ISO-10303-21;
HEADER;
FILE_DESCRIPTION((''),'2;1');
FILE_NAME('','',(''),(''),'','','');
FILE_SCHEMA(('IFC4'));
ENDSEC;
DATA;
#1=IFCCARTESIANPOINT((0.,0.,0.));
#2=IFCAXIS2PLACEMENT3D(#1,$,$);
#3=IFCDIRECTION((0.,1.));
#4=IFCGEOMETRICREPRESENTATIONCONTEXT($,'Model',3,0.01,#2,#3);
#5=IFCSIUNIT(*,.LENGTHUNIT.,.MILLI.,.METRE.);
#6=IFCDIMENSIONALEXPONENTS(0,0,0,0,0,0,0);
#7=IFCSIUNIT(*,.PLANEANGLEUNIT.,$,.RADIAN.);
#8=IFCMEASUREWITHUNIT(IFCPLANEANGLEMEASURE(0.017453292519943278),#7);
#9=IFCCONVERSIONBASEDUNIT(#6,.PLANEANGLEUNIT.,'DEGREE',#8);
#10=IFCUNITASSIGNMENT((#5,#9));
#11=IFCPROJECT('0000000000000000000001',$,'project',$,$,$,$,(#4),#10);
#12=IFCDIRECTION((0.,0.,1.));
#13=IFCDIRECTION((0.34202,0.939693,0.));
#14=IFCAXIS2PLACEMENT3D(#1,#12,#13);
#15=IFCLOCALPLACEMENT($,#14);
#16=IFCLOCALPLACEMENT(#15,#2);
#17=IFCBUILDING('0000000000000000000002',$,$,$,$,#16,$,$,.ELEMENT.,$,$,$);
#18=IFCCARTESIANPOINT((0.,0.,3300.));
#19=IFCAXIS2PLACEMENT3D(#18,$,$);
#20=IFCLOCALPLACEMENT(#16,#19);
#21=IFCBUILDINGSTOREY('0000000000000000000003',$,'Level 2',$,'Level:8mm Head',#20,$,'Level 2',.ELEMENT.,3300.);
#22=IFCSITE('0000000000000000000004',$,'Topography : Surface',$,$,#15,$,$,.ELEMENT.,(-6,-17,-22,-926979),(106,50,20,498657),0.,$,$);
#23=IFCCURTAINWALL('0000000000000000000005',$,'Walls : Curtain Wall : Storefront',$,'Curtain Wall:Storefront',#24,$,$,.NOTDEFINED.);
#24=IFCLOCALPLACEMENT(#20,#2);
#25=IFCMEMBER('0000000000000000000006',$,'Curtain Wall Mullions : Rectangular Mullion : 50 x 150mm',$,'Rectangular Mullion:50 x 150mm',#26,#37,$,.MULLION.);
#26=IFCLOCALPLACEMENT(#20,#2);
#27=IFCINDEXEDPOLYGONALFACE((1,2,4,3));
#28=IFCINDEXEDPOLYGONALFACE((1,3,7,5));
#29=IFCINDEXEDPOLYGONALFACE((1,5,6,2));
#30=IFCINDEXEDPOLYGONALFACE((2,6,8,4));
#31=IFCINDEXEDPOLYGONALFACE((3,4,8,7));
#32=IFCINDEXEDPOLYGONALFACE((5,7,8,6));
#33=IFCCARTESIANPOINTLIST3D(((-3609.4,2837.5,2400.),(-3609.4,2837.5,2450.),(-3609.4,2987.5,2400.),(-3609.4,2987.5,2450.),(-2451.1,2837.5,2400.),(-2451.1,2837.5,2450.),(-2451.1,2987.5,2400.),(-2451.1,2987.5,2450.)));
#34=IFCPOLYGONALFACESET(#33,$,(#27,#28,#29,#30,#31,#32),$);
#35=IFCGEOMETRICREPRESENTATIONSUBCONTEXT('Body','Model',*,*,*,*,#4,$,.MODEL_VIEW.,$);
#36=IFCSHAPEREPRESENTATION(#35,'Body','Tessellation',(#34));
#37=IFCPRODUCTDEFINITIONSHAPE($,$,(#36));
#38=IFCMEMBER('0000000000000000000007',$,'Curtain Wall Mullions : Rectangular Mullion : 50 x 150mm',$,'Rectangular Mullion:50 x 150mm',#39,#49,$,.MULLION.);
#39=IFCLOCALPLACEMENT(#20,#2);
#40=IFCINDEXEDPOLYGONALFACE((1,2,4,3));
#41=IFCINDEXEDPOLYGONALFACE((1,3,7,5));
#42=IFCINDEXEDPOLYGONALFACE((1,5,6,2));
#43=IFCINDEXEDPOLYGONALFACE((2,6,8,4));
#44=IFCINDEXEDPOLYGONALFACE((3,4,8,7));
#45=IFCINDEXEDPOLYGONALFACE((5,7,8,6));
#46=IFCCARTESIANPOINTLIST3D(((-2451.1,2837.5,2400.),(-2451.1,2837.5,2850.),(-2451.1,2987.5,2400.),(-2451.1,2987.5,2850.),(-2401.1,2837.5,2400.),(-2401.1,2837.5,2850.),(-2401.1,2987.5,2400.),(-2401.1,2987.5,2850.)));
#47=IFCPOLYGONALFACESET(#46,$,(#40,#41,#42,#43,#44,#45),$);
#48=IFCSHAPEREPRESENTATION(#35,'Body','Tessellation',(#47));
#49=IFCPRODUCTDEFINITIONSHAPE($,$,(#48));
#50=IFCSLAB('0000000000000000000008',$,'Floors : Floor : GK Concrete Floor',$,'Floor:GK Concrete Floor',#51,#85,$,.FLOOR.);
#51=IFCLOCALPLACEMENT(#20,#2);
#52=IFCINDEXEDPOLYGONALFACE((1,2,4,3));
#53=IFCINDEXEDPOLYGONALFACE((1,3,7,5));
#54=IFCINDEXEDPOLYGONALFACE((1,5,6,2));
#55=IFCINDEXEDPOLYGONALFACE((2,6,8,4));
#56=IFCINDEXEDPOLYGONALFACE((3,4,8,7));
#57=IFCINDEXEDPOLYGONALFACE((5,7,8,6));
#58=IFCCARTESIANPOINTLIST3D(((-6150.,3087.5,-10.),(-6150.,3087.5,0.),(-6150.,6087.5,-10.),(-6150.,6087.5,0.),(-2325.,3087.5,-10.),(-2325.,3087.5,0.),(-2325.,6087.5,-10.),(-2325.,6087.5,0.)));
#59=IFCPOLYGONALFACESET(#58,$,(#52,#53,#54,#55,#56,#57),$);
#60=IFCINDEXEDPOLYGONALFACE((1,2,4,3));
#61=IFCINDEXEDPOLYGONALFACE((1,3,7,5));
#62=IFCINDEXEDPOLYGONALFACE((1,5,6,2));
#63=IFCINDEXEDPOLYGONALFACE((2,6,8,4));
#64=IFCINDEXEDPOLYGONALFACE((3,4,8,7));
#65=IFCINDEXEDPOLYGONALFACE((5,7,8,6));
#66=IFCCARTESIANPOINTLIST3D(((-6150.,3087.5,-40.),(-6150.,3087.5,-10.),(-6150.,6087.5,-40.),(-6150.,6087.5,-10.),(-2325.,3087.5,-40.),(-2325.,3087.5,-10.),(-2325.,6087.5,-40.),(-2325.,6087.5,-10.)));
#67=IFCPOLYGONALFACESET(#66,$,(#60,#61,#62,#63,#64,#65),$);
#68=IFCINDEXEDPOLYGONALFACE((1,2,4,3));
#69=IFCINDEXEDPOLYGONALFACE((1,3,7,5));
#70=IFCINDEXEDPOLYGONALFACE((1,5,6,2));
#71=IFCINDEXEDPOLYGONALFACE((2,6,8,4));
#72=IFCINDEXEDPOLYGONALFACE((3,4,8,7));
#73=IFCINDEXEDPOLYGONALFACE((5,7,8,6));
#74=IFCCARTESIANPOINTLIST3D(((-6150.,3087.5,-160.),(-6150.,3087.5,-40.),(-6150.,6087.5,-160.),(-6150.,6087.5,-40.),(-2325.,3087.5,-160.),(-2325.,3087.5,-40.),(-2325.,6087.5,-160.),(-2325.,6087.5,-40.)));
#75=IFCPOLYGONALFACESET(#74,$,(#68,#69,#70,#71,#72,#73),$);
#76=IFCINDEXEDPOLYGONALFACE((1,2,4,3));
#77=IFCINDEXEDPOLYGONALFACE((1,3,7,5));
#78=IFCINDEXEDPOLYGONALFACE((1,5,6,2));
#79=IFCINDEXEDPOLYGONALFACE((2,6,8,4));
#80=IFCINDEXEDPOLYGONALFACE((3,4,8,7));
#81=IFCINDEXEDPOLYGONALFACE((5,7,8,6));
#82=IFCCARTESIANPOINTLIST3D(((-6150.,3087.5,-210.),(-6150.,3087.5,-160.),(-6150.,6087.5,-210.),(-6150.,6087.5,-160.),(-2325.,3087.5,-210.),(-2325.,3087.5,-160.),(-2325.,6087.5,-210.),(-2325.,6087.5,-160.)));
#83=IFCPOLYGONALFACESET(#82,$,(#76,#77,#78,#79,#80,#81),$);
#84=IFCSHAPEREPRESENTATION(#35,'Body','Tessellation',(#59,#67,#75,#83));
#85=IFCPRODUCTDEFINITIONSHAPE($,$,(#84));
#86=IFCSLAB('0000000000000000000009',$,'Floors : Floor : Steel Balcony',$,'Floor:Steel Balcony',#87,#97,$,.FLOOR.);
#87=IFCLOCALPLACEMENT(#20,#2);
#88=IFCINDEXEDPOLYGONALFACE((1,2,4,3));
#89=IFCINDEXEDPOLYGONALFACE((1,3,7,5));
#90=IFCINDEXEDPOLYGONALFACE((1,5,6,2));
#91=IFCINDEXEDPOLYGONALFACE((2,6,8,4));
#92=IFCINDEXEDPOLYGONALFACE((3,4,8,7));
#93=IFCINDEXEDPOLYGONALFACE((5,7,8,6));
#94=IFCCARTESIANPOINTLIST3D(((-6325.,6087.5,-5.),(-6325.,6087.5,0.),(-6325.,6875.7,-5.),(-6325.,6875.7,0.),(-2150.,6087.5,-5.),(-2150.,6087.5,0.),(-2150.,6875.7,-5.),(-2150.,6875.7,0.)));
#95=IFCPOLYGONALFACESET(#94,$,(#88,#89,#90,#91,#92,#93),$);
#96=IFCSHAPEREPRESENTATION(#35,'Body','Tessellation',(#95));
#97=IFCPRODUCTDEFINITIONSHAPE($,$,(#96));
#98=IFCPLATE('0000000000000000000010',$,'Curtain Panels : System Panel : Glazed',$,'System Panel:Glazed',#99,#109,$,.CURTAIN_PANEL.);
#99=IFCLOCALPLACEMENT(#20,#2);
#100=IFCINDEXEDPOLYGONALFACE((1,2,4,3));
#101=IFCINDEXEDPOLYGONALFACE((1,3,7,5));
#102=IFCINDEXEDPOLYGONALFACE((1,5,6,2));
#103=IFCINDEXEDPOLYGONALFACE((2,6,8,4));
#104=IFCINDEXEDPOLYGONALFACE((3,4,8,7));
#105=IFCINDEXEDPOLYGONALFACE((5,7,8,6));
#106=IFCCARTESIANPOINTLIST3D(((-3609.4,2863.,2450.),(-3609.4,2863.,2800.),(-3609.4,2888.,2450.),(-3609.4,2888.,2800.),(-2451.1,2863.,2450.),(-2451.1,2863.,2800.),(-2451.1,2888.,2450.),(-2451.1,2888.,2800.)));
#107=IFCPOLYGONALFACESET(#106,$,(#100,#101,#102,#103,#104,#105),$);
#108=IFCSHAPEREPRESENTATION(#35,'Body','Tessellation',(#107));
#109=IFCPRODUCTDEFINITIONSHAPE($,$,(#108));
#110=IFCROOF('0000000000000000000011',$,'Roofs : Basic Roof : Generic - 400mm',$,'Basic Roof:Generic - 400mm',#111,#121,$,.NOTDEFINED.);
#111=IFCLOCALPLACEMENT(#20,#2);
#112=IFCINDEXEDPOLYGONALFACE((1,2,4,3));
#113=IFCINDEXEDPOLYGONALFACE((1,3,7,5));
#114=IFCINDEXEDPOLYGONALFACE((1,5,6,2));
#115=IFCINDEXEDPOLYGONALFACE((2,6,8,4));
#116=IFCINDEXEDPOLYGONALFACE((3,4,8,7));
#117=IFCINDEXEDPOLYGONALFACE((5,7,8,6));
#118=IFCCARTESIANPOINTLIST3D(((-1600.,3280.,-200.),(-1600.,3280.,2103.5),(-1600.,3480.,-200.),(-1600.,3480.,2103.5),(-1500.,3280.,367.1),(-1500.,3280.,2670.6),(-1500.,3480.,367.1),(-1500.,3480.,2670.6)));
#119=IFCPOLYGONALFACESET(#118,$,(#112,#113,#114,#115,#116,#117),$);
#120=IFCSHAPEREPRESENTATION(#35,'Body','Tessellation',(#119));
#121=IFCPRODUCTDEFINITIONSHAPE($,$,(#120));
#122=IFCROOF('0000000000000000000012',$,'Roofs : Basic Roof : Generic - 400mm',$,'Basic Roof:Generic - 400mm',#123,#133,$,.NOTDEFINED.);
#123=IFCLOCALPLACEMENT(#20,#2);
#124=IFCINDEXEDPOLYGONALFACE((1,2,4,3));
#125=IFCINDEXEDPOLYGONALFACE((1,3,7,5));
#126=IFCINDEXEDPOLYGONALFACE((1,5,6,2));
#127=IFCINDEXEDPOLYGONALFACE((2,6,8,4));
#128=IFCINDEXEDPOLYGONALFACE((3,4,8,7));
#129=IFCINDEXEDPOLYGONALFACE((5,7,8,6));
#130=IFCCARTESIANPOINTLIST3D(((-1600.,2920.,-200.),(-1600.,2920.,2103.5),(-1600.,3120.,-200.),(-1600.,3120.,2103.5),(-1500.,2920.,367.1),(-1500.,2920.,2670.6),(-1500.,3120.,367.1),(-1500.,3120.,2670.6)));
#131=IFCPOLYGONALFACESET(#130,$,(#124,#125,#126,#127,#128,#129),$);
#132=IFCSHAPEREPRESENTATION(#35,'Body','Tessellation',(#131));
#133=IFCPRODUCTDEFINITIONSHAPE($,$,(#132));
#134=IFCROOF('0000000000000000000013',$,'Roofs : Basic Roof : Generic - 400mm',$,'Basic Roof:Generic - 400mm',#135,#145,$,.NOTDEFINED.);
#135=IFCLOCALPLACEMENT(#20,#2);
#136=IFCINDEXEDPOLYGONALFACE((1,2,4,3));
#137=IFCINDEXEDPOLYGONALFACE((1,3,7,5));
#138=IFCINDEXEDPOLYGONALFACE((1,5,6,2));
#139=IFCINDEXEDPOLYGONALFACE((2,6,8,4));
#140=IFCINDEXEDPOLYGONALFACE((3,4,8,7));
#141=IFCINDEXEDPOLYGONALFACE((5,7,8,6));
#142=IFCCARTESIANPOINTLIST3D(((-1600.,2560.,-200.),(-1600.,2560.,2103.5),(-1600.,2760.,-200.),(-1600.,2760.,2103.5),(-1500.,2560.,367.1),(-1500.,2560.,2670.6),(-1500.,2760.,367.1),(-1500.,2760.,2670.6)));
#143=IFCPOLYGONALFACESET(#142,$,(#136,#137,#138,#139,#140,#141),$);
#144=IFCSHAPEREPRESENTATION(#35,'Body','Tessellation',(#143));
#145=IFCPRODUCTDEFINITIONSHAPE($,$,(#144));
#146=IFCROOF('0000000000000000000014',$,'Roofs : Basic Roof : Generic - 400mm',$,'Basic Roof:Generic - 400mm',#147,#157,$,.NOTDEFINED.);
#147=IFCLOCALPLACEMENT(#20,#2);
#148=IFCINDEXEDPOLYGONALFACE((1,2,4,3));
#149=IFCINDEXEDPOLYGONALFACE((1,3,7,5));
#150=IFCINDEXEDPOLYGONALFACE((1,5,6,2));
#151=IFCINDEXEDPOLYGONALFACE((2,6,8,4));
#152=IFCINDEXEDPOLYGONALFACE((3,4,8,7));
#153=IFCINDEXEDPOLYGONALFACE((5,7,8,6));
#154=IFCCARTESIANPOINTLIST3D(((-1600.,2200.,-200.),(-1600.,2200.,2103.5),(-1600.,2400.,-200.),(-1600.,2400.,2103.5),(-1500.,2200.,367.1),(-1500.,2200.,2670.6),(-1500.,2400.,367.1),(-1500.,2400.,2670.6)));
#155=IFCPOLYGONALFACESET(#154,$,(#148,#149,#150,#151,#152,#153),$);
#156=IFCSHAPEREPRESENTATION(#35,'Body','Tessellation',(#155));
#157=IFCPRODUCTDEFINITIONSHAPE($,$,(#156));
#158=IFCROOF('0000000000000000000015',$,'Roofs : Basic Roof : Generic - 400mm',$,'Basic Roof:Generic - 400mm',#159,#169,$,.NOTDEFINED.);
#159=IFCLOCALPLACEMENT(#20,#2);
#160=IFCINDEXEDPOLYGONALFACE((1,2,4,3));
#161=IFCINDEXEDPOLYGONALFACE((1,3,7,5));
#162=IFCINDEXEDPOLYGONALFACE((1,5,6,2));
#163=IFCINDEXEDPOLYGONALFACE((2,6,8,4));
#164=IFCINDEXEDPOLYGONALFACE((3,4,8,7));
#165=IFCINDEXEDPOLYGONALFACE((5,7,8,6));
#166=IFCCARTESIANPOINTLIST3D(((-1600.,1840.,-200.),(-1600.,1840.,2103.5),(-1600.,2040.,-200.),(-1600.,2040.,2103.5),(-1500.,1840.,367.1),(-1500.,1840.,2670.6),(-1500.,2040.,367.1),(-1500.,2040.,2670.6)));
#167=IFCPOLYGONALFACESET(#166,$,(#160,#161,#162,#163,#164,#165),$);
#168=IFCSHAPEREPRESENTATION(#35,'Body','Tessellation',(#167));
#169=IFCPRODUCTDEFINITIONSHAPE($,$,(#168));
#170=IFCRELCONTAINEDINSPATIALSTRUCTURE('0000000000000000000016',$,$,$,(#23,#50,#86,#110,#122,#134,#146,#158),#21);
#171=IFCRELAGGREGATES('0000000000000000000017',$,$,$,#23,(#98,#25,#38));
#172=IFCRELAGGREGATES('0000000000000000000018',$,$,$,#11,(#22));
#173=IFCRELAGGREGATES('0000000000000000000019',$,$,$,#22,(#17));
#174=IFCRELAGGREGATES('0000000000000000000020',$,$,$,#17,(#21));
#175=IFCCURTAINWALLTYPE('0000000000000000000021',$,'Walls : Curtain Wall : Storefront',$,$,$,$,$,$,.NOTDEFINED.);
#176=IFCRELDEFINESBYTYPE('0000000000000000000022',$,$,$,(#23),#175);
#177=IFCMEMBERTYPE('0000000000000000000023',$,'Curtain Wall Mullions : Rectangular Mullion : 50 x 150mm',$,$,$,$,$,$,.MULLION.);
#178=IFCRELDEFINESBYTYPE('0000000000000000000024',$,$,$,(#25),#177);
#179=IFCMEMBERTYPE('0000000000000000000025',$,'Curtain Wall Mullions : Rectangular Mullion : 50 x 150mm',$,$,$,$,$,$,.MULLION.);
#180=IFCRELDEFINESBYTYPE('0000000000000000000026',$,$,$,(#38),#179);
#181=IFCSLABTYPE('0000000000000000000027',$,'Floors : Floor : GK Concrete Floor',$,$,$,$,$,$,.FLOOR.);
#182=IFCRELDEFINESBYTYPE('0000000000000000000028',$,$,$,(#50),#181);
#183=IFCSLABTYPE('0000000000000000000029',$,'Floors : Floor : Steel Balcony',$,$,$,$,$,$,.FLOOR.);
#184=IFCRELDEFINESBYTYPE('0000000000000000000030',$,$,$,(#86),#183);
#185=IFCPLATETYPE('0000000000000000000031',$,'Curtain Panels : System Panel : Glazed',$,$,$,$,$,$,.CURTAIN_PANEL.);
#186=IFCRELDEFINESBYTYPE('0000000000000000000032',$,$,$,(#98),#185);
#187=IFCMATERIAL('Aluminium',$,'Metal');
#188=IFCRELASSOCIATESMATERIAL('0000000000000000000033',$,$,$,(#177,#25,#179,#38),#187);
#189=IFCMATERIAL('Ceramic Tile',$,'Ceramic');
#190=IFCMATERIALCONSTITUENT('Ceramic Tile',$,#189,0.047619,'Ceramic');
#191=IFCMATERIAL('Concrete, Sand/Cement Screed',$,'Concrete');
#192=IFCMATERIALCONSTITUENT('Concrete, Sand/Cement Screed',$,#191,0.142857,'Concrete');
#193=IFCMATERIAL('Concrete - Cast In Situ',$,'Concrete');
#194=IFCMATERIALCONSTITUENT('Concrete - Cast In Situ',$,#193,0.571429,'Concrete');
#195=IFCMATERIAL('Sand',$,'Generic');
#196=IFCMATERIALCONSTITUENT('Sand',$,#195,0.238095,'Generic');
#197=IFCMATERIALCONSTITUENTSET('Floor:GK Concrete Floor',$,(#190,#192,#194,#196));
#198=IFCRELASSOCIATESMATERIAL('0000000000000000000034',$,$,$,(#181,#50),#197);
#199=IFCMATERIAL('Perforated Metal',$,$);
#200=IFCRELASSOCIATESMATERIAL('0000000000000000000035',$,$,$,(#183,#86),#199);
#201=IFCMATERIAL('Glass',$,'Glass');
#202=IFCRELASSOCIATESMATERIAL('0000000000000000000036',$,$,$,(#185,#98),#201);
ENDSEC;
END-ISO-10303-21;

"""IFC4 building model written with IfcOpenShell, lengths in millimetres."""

from ifc_helpers import new_model, entity, si_unit, converted_unit, direction, frame, origin, place, context, subcontext, project, spatial, indexed_curve, outline, extrude, source, transform, mapped, material, constituent, constituent_set, type_object, type_shapes, element, aggregate, save


model = new_model("IFC4")

# Units and contexts
model_context = context("Model", 3, precision=0.01, world=origin(), true_north=direction((0.0, 1.0)))
body_context = subcontext(model_context, "Body", "Model", "MODEL_VIEW")
ifc_project = project(units=[si_unit("LENGTHUNIT", "METRE", prefix="MILLI"), converted_unit("PLANEANGLEUNIT", "DEGREE", entity("IfcPlaneAngleMeasure", 0.017453292519943278), si_unit("PLANEANGLEUNIT", "RADIAN"), dimensions=[0, 0, 0, 0, 0, 0, 0])], contexts=[model_context])

# Site, building, storey
site_placement = place(None, frame((0.0, 0.0, 0.0), z_axis=(0.0, 0.0, 1.0), x_axis=(0.34202, 0.939693, 0.0)))
site = spatial("IfcSite", under=ifc_project, at=site_placement, Name="Topography : Surface", CompositionType="ELEMENT", RefLatitude=(-6, -17, -22, -926979), RefLongitude=(106, 50, 20, 498657), RefElevation=0.0)
building_placement = place(site_placement, origin())
building = spatial("IfcBuilding", under=site, at=building_placement, CompositionType="ELEMENT")
storey_placement = place(building_placement, frame((0.0, 0.0, 3300.0)))
storey = spatial("IfcBuildingStorey", under=building, at=storey_placement, Name="Level 2", ObjectType="Level:8mm Head", LongName="Level 2", CompositionType="ELEMENT", Elevation=3300.0)

# Curtain wall, members
curtain_wall_type = type_object("IfcCurtainWallType", Name="Walls : Curtain Wall : Storefront", PredefinedType="NOTDEFINED")
curtain_wall_placement = place(storey_placement, frame((0.0, 0.0, -3300.0)))
curtain_wall = element("IfcCurtainWall", 1, at=curtain_wall_placement, inside=storey, type_object=curtain_wall_type, Name="Walls : Curtain Wall : Storefront", ObjectType="Curtain Wall:Storefront", PredefinedType="NOTDEFINED")
ifc_material_1 = material(Name="Aluminium", Category="Metal")
member_type_1 = type_object("IfcMemberType", Name="Curtain Wall Mullions : Rectangular Mullion : 50 x 150mm", PredefinedType="MULLION", material=ifc_material_1)
shared_shape_1 = source(origin(), body_context, "Body", "SweptSolid", [
    extrude(outline(indexed_curve([(-25.0, -75.0), (25.0, -75.0), (25.0, 75.0), (-25.0, 75.0), (-25.0, -75.0)], self_intersect=False)), frame((-25.0, 0.0, -1158.3), z_axis=(0.0, 0.0, 1.0), x_axis=(-1.0, 0.0, 0.0)), (0.0, 0.0, 1.0), 1158.3),
])
type_shapes(member_type_1, [shared_shape_1])
member_1_placement = place(curtain_wall_placement, frame((-2451.1, 2912.5, 5700.0), z_axis=(1.0, 0.0, 0.0), x_axis=(0.0, 0.0, -1.0)))
member_1 = element("IfcMember", 2, at=member_1_placement, type_object=member_type_1, material=ifc_material_1, Name="Curtain Wall Mullions : Rectangular Mullion : 50 x 150mm", ObjectType="Rectangular Mullion:50 x 150mm", PredefinedType="MULLION", context=body_context, shape_type="MappedRepresentation", body=[
    mapped(shared_shape_1, transform((0.0, 0.0, 0.0), scale=1.0)),
])
member_type_2 = type_object("IfcMemberType", Name="Curtain Wall Mullions : Rectangular Mullion : 50 x 150mm", PredefinedType="MULLION", material=ifc_material_1)
shared_shape_2 = source(origin(), body_context, "Body", "SweptSolid", [
    extrude(outline(indexed_curve([(-25.0, -75.0), (25.0, -75.0), (25.0, 75.0), (-25.0, 75.0), (-25.0, -75.0)], self_intersect=False)), frame((-25.0, 0.0, -450.0), z_axis=(0.0, 0.0, 1.0), x_axis=(-1.0, 0.0, 0.0)), (0.0, 0.0, 1.0), 450.0),
])
type_shapes(member_type_2, [shared_shape_2])
member_2_placement = place(curtain_wall_placement, frame((-2401.1, 2912.5, 6150.0)))
member_2 = element("IfcMember", 3, at=member_2_placement, type_object=member_type_2, material=ifc_material_1, Name="Curtain Wall Mullions : Rectangular Mullion : 50 x 150mm", ObjectType="Rectangular Mullion:50 x 150mm", PredefinedType="MULLION", context=body_context, shape_type="MappedRepresentation", body=[
    mapped(shared_shape_2, transform((0.0, 0.0, 0.0), scale=1.0)),
])

# Slabs
ifc_material_2 = material(Name="Ceramic Tile", Category="Ceramic")
ifc_constituent_1 = constituent(ifc_material_2, Name="Ceramic Tile", Category="Ceramic", fraction=0.047619)
ifc_material_3 = material(Name="Concrete, Sand/Cement Screed", Category="Concrete")
ifc_constituent_2 = constituent(ifc_material_3, Name="Concrete, Sand/Cement Screed", Category="Concrete", fraction=0.142857)
ifc_material_4 = material(Name="Concrete - Cast In Situ", Category="Concrete")
ifc_constituent_3 = constituent(ifc_material_4, Name="Concrete - Cast In Situ", Category="Concrete", fraction=0.571429)
ifc_material_5 = material(Name="Sand", Category="Generic")
ifc_constituent_4 = constituent(ifc_material_5, Name="Sand", Category="Generic", fraction=0.238095)
ifc_constituent_set_1 = constituent_set(constituents=[ifc_constituent_1, ifc_constituent_2, ifc_constituent_3, ifc_constituent_4], Name="Floor:GK Concrete Floor")
slab_type_1 = type_object("IfcSlabType", Name="Floors : Floor : GK Concrete Floor", PredefinedType="FLOOR", material=ifc_constituent_set_1)
slab_1_placement = place(storey_placement, origin())
element("IfcSlab", 4, at=slab_1_placement, inside=storey, type_object=slab_type_1, material=ifc_constituent_set_1, Name="Floors : Floor : GK Concrete Floor", ObjectType="Floor:GK Concrete Floor", PredefinedType="FLOOR", context=body_context, shape_type="SweptSolid", body=[
    extrude(outline(indexed_curve([(-1912.5, -1500.0), (1912.5, -1500.0), (1912.5, 1500.0), (-1912.5, 1500.0), (-1912.5, -1500.0)], self_intersect=False)), frame((-4237.5, 4587.5, -10.0), z_axis=(0.0, 0.0, 1.0), x_axis=(-1.0, 0.0, 0.0)), (0.0, 0.0, 1.0), 10.0),
    extrude(outline(indexed_curve([(-1912.5, -1500.0), (1912.5, -1500.0), (1912.5, 1500.0), (-1912.5, 1500.0), (-1912.5, -1500.0)], self_intersect=False)), frame((-4237.5, 4587.5, -40.0), z_axis=(0.0, 0.0, 1.0), x_axis=(-1.0, 0.0, 0.0)), (0.0, 0.0, 1.0), 30.0),
    extrude(outline(indexed_curve([(-1912.5, -1500.0), (1912.5, -1500.0), (1912.5, 1500.0), (-1912.5, 1500.0), (-1912.5, -1500.0)], self_intersect=False)), frame((-4237.5, 4587.5, -160.0), z_axis=(0.0, 0.0, 1.0), x_axis=(-1.0, 0.0, 0.0)), (0.0, 0.0, 1.0), 120.0),
    extrude(outline(indexed_curve([(-1912.5, -1500.0), (1912.5, -1500.0), (1912.5, 1500.0), (-1912.5, 1500.0), (-1912.5, -1500.0)], self_intersect=False)), frame((-4237.5, 4587.5, -210.0), z_axis=(0.0, 0.0, 1.0), x_axis=(-1.0, 0.0, 0.0)), (0.0, 0.0, 1.0), 50.0),
])
ifc_material_6 = material(Name="Perforated Metal")
slab_type_2 = type_object("IfcSlabType", Name="Floors : Floor : Steel Balcony", PredefinedType="FLOOR", material=ifc_material_6)
slab_2_placement = place(storey_placement, origin())
element("IfcSlab", 5, at=slab_2_placement, inside=storey, type_object=slab_type_2, material=ifc_material_6, Name="Floors : Floor : Steel Balcony", ObjectType="Floor:Steel Balcony", PredefinedType="FLOOR", context=body_context, shape_type="SweptSolid", body=[
    extrude(outline(indexed_curve([(-394.1, -2087.5), (394.1, -2087.5), (394.1, 2087.5), (-394.1, 2087.5), (-394.1, -2087.5)], self_intersect=False)), frame((-4237.5, 6481.6, 0.0), z_axis=(0.0, 0.0, -1.0), x_axis=(0.0, 1.0, 0.0)), (0.0, 0.0, 1.0), 5.0),
])

# Plate
ifc_material_7 = material(Name="Glass", Category="Glass")
plate_type = type_object("IfcPlateType", Name="Curtain Panels : System Panel : Glazed", PredefinedType="CURTAIN_PANEL", material=ifc_material_7)
shared_shape_3 = source(origin(), body_context, "Body", "SweptSolid", [
    extrude(outline(indexed_curve([(-12.5, -579.2), (12.5, -579.2), (12.5, 579.2), (-12.5, 579.2), (-12.5, -579.2)], self_intersect=False)), frame((579.2, 12.5, 0.0), z_axis=(0.0, 0.0, 1.0), x_axis=(0.0, 1.0, 0.0)), (0.0, 0.0, 1.0), 350.0),
])
type_shapes(plate_type, [shared_shape_3])
plate_placement = place(curtain_wall_placement, frame((-2451.1, 2888.0, 5750.0), z_axis=(0.0, 0.0, 1.0), x_axis=(-1.0, 0.0, 0.0)))
plate = element("IfcPlate", 6, at=plate_placement, type_object=plate_type, material=ifc_material_7, Name="Curtain Panels : System Panel : Glazed", ObjectType="System Panel:Glazed", PredefinedType="CURTAIN_PANEL", context=body_context, shape_type="MappedRepresentation", body=[
    mapped(shared_shape_3, transform((0.0, 0.0, 0.0), scale=1.0)),
])
aggregate(curtain_wall, [plate, member_1, member_2])

# Roofs
roof_1_placement = place(storey_placement, frame((-1600.0, 3280.0, -200.0)))
element("IfcRoof", 7, at=roof_1_placement, inside=storey, Name="Roofs : Basic Roof : Generic - 400mm", ObjectType="Basic Roof:Generic - 400mm", PredefinedType="NOTDEFINED", context=body_context, shape_type="SweptSolid", body=[
    extrude(outline(indexed_curve([(-287.9, 100.0), (-287.9, -100.0), (287.9, -100.0), (287.9, 100.0), (-287.9, 100.0)], self_intersect=False)), frame((50.0, 100.0, 283.6), z_axis=(-0.984808, 0.0, 0.173648), x_axis=(0.173648, 0.0, 0.984808)), (0.984808, 0.0, 0.173648), 2303.5),
])
roof_2_placement = place(storey_placement, frame((-1600.0, 2920.0, -200.0)))
element("IfcRoof", 8, at=roof_2_placement, inside=storey, Name="Roofs : Basic Roof : Generic - 400mm", ObjectType="Basic Roof:Generic - 400mm", PredefinedType="NOTDEFINED", context=body_context, shape_type="SweptSolid", body=[
    extrude(outline(indexed_curve([(-287.9, 100.0), (-287.9, -100.0), (287.9, -100.0), (287.9, 100.0), (-287.9, 100.0)], self_intersect=False)), frame((50.0, 100.0, 283.6), z_axis=(-0.984808, 0.0, 0.173648), x_axis=(0.173648, 0.0, 0.984808)), (0.984808, 0.0, 0.173648), 2303.5),
])
roof_3_placement = place(storey_placement, frame((-1600.0, 2560.0, -200.0)))
element("IfcRoof", 9, at=roof_3_placement, inside=storey, Name="Roofs : Basic Roof : Generic - 400mm", ObjectType="Basic Roof:Generic - 400mm", PredefinedType="NOTDEFINED", context=body_context, shape_type="SweptSolid", body=[
    extrude(outline(indexed_curve([(-287.9, 100.0), (-287.9, -100.0), (287.9, -100.0), (287.9, 100.0), (-287.9, 100.0)], self_intersect=False)), frame((50.0, 100.0, 283.6), z_axis=(-0.984808, 0.0, 0.173648), x_axis=(0.173648, 0.0, 0.984808)), (0.984808, 0.0, 0.173648), 2303.5),
])
roof_4_placement = place(storey_placement, frame((-1600.0, 2200.0, -200.0)))
element("IfcRoof", 10, at=roof_4_placement, inside=storey, Name="Roofs : Basic Roof : Generic - 400mm", ObjectType="Basic Roof:Generic - 400mm", PredefinedType="NOTDEFINED", context=body_context, shape_type="SweptSolid", body=[
    extrude(outline(indexed_curve([(-287.9, 100.0), (-287.9, -100.0), (287.9, -100.0), (287.9, 100.0), (-287.9, 100.0)], self_intersect=False)), frame((50.0, 100.0, 283.6), z_axis=(-0.984808, 0.0, 0.173648), x_axis=(0.173648, 0.0, 0.984808)), (0.984808, 0.0, 0.173648), 2303.5),
])
roof_5_placement = place(storey_placement, frame((-1600.0, 1840.0, -200.0)))
element("IfcRoof", 11, at=roof_5_placement, inside=storey, Name="Roofs : Basic Roof : Generic - 400mm", ObjectType="Basic Roof:Generic - 400mm", PredefinedType="NOTDEFINED", context=body_context, shape_type="SweptSolid", body=[
    extrude(outline(indexed_curve([(-287.9, 100.0), (-287.9, -100.0), (287.9, -100.0), (287.9, 100.0), (-287.9, 100.0)], self_intersect=False)), frame((50.0, 100.0, 283.6), z_axis=(-0.984808, 0.0, 0.173648), x_axis=(0.173648, 0.0, 0.984808)), (0.984808, 0.0, 0.173648), 2303.5),
])

save(model, "model.ifc")
